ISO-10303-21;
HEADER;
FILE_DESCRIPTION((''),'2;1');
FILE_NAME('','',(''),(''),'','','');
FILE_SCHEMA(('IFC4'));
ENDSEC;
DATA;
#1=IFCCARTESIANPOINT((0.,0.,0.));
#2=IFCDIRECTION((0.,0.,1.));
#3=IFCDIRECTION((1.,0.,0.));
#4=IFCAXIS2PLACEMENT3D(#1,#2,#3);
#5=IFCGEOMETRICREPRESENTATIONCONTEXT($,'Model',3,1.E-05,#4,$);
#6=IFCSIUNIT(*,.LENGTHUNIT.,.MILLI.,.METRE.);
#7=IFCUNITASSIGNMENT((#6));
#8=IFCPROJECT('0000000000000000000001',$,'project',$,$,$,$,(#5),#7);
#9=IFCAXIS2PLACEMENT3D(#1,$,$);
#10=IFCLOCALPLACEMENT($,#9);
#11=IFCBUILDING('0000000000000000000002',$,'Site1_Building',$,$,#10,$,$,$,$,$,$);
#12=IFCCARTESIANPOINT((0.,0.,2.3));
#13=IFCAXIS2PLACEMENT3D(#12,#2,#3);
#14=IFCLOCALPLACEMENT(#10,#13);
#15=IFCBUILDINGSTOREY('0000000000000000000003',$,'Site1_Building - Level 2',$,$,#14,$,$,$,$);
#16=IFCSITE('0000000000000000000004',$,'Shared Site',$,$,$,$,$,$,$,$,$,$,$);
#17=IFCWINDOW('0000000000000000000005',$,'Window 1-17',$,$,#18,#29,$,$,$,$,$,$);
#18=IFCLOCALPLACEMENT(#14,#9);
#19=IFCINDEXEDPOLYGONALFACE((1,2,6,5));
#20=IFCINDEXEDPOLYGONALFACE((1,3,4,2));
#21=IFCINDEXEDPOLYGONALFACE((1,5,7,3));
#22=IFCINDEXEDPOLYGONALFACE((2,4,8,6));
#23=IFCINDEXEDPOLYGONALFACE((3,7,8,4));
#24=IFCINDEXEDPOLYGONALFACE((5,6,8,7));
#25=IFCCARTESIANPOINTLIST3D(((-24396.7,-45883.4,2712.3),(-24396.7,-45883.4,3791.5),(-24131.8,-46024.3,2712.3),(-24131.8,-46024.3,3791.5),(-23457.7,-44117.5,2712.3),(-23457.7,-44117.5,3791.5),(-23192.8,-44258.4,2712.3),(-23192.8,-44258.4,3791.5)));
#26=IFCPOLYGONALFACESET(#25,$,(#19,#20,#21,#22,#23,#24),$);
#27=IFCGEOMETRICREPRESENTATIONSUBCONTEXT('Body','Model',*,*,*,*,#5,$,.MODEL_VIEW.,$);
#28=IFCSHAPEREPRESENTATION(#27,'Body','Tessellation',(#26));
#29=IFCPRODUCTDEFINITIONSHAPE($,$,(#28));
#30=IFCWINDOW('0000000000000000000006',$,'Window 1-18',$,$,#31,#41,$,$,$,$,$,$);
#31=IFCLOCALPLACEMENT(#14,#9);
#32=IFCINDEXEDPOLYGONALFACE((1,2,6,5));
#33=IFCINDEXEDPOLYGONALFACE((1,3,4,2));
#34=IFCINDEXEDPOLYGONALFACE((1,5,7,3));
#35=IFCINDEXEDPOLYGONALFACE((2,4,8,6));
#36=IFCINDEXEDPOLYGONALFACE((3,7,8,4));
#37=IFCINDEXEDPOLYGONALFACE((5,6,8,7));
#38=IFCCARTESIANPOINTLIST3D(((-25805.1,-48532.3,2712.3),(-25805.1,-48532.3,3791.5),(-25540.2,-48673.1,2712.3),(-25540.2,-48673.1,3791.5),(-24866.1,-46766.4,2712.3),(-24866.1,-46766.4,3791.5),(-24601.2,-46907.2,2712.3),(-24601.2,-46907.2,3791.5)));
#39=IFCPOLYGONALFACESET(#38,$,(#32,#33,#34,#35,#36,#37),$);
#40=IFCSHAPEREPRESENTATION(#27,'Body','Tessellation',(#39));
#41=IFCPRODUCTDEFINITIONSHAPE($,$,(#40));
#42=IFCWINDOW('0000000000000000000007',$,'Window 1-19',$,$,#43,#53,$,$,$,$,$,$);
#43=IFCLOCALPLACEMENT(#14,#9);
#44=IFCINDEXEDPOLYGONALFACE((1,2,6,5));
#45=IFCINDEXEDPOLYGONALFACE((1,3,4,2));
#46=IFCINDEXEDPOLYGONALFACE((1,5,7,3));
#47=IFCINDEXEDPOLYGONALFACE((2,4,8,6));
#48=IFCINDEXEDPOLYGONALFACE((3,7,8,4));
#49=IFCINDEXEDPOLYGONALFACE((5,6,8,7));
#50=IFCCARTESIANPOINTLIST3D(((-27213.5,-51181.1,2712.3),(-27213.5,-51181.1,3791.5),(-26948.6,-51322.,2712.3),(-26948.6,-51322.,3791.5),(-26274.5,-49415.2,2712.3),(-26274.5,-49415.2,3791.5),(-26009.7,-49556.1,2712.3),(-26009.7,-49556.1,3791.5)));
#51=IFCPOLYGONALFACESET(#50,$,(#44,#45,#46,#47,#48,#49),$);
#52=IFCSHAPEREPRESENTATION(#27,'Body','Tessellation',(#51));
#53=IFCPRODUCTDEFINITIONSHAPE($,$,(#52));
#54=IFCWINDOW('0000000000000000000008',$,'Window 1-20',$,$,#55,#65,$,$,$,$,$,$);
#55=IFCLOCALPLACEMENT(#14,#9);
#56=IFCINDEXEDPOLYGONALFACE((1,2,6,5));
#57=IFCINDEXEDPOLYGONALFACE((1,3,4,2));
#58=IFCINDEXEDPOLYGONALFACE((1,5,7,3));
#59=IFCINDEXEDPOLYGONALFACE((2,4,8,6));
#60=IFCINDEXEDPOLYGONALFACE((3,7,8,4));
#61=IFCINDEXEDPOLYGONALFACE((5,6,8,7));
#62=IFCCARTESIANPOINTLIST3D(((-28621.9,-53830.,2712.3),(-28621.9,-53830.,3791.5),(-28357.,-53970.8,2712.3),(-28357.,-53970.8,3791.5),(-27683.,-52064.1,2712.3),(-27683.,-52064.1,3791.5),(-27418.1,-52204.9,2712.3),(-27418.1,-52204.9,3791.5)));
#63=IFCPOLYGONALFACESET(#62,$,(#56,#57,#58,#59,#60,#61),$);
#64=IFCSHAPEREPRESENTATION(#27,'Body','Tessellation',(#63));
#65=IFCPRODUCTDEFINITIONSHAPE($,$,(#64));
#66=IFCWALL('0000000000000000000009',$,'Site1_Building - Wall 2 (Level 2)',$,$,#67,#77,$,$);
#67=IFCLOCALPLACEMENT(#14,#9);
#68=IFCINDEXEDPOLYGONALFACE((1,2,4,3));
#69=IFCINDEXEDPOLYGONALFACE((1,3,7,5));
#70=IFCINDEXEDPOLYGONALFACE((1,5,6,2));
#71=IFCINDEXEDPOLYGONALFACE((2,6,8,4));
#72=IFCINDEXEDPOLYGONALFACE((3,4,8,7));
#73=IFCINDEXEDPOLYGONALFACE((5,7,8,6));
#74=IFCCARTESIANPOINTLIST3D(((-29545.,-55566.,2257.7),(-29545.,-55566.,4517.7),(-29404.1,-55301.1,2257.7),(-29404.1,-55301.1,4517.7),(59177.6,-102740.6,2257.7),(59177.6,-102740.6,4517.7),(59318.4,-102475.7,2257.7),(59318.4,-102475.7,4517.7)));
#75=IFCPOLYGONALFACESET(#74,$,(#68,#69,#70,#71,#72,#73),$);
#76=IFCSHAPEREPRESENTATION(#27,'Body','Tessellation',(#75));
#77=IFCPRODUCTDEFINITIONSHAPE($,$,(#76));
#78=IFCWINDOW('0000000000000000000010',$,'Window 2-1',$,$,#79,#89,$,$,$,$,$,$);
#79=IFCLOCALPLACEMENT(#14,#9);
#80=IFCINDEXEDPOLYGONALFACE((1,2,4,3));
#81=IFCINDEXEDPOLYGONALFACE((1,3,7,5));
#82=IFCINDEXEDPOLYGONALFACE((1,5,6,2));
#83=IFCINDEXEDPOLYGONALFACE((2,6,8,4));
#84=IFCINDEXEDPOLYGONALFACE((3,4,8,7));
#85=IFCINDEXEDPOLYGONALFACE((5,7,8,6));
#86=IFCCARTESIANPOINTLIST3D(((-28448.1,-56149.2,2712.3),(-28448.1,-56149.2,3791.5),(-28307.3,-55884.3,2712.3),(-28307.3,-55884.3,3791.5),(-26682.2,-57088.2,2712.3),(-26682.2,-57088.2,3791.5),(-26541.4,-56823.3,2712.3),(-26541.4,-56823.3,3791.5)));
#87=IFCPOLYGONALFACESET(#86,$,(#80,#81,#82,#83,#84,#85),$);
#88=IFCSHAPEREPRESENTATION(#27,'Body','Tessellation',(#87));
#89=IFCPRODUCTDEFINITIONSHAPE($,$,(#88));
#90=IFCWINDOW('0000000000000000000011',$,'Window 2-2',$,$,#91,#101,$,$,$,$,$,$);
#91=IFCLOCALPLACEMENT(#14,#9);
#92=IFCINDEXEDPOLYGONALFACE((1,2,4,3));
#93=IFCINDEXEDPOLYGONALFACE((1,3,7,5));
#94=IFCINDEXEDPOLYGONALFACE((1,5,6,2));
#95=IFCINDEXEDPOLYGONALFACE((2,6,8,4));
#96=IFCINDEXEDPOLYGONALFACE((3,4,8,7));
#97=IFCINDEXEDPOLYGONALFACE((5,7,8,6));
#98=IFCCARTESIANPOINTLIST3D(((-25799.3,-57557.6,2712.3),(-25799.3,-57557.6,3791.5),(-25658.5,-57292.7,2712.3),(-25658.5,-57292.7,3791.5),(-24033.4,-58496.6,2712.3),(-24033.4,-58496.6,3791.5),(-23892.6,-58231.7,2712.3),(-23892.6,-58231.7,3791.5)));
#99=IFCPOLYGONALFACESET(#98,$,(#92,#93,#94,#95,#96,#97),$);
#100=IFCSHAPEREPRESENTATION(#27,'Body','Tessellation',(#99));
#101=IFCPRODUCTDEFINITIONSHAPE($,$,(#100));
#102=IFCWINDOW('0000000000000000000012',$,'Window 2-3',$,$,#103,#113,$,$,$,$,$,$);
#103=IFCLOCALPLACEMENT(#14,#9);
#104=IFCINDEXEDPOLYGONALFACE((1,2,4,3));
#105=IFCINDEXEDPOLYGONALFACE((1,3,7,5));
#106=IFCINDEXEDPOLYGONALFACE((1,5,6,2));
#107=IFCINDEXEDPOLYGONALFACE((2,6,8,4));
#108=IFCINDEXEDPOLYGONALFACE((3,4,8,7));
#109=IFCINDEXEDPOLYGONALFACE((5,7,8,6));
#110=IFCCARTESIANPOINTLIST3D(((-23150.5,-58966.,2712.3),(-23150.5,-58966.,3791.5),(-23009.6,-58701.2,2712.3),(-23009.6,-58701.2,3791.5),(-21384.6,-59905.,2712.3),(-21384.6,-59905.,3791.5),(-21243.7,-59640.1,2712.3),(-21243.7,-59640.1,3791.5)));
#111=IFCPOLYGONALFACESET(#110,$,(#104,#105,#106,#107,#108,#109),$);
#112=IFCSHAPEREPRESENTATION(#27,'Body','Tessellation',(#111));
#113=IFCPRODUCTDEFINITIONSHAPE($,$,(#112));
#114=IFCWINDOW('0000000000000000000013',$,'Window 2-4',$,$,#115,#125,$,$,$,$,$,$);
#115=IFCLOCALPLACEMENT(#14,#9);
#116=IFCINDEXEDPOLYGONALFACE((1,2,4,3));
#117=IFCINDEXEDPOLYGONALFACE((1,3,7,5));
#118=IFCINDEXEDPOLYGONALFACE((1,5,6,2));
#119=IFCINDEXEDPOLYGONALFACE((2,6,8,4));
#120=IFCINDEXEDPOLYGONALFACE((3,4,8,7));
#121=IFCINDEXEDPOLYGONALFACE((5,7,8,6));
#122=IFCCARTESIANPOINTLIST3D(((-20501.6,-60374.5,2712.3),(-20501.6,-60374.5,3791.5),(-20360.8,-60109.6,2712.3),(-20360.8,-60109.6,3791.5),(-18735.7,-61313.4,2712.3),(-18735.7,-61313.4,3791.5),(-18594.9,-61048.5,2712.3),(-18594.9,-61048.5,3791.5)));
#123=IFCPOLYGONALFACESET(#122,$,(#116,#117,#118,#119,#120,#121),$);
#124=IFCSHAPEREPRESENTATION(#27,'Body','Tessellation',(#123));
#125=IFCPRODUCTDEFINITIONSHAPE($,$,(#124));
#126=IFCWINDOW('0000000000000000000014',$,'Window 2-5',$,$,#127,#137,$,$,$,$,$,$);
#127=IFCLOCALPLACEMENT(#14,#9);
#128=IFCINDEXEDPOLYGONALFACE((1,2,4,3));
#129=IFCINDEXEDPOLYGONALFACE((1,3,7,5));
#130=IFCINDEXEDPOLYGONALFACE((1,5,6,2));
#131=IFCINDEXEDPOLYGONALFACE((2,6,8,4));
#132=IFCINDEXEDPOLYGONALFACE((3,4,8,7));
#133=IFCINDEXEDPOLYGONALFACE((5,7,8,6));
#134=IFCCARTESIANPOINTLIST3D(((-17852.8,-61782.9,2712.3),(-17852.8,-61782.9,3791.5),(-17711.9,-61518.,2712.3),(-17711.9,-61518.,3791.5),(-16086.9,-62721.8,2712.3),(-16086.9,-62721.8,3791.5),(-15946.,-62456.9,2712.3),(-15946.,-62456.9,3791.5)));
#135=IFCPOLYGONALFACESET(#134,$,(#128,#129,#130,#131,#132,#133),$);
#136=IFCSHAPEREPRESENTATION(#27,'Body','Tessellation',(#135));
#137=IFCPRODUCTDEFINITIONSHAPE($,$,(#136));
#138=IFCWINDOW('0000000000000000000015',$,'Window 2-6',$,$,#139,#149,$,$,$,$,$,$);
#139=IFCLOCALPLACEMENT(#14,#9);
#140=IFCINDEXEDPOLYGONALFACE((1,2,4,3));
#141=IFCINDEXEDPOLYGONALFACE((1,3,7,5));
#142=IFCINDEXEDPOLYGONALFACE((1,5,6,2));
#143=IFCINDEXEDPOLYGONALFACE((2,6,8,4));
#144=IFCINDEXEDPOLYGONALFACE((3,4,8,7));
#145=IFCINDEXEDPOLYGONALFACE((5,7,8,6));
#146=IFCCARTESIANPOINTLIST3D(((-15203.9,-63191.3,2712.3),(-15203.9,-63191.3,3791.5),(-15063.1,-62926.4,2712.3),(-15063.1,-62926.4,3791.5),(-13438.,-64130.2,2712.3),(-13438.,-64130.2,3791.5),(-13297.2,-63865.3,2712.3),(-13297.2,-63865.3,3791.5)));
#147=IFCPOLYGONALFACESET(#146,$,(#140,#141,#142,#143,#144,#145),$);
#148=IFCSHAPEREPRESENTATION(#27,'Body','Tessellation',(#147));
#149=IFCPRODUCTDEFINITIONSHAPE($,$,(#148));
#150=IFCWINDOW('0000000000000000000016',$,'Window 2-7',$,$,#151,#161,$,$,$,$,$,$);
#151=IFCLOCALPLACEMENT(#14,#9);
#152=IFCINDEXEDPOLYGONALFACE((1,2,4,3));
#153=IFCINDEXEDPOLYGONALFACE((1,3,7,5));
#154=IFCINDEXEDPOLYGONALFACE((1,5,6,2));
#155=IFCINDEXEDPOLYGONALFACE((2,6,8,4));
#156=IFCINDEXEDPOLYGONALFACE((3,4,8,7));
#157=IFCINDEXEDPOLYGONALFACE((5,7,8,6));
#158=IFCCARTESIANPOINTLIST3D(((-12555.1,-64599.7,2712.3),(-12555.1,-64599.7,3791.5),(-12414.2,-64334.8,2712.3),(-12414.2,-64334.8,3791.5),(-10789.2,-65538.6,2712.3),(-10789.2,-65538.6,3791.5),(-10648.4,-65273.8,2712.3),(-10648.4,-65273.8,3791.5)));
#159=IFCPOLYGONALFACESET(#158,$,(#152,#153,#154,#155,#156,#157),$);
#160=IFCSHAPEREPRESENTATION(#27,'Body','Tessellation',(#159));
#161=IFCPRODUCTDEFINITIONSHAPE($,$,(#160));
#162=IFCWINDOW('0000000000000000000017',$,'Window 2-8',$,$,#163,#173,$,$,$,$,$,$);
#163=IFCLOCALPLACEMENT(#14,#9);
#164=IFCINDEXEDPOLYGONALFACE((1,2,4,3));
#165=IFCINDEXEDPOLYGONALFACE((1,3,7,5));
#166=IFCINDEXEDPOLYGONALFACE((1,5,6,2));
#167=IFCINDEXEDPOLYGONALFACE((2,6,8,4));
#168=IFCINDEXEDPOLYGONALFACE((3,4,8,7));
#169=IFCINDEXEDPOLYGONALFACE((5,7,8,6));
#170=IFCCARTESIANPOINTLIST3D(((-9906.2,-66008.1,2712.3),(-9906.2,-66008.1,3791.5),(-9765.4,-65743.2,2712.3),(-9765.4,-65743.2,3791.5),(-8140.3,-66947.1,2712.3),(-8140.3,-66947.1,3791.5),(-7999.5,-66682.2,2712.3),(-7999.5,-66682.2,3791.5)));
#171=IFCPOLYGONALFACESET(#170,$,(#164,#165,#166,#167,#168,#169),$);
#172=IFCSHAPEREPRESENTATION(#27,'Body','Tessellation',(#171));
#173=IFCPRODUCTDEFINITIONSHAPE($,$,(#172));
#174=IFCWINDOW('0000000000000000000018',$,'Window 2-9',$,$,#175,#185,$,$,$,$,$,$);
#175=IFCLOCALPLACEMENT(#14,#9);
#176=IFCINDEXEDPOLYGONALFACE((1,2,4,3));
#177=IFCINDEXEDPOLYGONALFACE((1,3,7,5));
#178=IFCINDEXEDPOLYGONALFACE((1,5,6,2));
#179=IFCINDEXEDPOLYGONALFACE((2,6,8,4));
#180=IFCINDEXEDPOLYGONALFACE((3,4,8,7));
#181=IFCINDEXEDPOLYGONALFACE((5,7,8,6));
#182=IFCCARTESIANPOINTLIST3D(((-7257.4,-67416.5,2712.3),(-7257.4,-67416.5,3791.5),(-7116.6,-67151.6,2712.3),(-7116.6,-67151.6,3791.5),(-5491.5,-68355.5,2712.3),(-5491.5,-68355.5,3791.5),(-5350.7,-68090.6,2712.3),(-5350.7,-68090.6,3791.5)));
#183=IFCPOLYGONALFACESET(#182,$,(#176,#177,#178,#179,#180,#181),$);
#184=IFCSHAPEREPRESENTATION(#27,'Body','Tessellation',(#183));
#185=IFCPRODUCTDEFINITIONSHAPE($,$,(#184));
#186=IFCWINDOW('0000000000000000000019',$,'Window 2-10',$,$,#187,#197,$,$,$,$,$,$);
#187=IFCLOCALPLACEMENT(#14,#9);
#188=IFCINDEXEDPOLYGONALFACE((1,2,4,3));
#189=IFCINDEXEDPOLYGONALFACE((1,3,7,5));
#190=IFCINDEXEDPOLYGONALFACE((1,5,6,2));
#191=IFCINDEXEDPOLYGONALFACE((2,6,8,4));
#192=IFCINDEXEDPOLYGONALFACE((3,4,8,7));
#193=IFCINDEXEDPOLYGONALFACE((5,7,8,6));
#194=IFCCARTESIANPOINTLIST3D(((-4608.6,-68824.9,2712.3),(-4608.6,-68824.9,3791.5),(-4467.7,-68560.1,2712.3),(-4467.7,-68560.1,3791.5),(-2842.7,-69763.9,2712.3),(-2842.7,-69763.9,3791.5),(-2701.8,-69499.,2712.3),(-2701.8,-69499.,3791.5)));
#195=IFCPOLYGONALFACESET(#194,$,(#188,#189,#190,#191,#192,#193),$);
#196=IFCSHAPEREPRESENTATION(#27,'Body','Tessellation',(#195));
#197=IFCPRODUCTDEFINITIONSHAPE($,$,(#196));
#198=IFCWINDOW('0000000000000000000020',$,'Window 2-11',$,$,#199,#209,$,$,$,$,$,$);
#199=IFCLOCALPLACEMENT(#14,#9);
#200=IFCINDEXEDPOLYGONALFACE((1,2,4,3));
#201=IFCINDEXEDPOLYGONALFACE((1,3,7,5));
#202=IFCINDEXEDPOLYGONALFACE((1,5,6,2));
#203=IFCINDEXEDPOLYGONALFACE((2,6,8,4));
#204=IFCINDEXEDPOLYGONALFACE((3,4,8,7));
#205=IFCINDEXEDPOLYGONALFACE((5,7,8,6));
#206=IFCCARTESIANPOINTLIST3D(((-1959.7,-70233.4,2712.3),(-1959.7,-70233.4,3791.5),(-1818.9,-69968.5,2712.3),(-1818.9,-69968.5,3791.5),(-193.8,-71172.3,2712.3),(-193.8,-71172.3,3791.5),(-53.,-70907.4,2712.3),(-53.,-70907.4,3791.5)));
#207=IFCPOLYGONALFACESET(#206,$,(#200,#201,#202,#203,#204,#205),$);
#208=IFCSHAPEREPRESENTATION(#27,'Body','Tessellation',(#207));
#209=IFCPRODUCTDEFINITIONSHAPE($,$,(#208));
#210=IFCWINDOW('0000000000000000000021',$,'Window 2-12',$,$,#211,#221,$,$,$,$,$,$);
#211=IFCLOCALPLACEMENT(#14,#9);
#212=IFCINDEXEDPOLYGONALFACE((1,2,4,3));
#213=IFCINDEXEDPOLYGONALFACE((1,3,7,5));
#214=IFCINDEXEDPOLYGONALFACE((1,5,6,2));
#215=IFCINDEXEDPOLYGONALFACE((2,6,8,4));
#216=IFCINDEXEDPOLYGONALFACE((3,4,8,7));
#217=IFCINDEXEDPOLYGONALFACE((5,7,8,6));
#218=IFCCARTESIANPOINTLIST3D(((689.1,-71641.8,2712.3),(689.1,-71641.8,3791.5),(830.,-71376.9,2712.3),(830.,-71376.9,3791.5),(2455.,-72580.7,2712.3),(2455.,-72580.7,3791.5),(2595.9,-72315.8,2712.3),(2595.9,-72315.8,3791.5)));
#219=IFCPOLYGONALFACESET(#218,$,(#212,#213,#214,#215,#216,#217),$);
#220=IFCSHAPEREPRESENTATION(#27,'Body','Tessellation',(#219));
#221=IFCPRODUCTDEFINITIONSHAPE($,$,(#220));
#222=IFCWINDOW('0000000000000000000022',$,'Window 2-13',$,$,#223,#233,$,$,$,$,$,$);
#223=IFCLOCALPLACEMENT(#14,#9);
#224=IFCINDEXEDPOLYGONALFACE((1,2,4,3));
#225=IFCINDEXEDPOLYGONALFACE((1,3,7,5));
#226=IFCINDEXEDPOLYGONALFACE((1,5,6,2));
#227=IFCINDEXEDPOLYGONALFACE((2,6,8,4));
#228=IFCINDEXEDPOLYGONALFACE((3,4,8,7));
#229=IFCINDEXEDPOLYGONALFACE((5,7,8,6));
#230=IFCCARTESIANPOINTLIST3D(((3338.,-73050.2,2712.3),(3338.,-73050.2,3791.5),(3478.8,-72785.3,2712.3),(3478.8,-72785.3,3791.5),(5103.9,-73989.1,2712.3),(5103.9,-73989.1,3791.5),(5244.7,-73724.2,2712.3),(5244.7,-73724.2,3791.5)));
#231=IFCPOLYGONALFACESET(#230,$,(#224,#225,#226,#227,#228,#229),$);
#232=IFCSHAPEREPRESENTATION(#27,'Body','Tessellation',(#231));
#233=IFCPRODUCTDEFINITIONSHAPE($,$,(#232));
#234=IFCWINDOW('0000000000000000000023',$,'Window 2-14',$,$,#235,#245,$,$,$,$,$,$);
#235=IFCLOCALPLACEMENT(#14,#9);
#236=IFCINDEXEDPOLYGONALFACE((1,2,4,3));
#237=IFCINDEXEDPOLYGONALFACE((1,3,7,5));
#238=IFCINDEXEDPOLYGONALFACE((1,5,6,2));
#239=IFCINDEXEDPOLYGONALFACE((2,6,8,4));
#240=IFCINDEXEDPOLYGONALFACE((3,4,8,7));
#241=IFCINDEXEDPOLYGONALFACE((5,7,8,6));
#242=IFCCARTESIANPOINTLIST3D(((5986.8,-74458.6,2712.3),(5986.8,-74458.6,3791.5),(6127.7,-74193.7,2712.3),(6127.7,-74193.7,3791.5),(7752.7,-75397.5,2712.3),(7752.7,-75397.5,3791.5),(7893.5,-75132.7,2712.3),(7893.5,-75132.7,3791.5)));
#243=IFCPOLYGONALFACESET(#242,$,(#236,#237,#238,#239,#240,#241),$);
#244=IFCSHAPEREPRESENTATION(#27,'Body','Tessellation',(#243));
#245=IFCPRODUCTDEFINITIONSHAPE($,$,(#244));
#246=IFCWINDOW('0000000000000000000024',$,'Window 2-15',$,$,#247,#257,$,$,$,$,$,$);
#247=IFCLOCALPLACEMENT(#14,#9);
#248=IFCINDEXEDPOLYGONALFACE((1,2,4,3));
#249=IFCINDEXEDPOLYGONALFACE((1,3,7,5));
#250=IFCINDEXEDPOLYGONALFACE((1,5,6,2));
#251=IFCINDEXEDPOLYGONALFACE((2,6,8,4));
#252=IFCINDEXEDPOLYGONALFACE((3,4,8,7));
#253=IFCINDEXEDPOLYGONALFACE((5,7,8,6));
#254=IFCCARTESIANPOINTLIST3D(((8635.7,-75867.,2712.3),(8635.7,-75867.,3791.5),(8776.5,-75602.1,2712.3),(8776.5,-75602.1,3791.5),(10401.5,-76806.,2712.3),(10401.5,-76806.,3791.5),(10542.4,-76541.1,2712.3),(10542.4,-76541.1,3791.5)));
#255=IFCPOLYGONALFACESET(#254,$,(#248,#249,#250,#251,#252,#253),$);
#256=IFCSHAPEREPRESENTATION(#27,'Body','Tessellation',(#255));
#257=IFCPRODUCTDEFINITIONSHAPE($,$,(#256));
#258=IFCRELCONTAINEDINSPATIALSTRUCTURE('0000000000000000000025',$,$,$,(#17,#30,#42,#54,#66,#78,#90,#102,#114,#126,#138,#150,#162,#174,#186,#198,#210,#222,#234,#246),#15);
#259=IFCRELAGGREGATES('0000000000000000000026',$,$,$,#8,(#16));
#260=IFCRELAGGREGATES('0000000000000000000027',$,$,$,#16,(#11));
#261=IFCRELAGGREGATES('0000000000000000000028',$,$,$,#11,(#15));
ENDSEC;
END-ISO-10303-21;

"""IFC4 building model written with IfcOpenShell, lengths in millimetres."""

from ifc_helpers import new_model, si_unit, frame, origin, origin_with_axes, place, context, subcontext, project, spatial, indexed_curve, outline, extrude, element, save


model = new_model("IFC4")

# Units and contexts
model_context = context("Model", 3, precision=1e-05, world=origin_with_axes())
body_context = subcontext(model_context, "Body", "Model", "MODEL_VIEW")
ifc_project = project(units=[si_unit("LENGTHUNIT", "METRE", prefix="MILLI")], contexts=[model_context])

# Site, building, storey
site = spatial("IfcSite", under=ifc_project, Name="Shared Site")
building_placement = place(None, origin())
building = spatial("IfcBuilding", under=site, at=building_placement, Name="Site1_Building")
storey_placement = place(building_placement, frame((0.0, 0.0, 2.3), z_axis=(0.0, 0.0, 1.0), x_axis=(1.0, 0.0, 0.0)))
storey = spatial("IfcBuildingStorey", under=building, at=storey_placement, Name="Site1_Building - Level 2")

# Windows
for number, where, z_axis, x_axis, name in (
    (1, (-23457.7, -44117.5, 2712.3), (0.0, 0.0, 1.0), (-0.469472, -0.882948, 0.0), "Window 1-17"),
    (2, (-24866.1, -46766.4, 2712.3), (0.0, 0.0, 1.0), (-0.469472, -0.882948, 0.0), "Window 1-18"),
    (3, (-26274.5, -49415.2, 2712.3), (0.0, 0.0, 1.0), (-0.469472, -0.882948, 0.0), "Window 1-19"),
    (4, (-27683.0, -52064.1, 2712.3), (0.0, 0.0, 1.0), (-0.469472, -0.882948, 0.0), "Window 1-20"),
):
    element("IfcWindow", number, at=place(storey_placement, frame(where, z_axis=z_axis, x_axis=x_axis)), inside=storey, Name=name, context=body_context, shape_type="SweptSolid", body=[
        extrude(outline(indexed_curve([(0.0, 0.0), (0.0, 300.0), (2000.0, 300.0), (2000.0, 0.0), (0.0, 0.0)], self_intersect=False)), origin_with_axes(), (0.0, 0.0, 1.0), 1079.3),
    ])

# Wall
wall_placement = place(storey_placement, frame((-29545.0, -55566.0, 2257.7), z_axis=(0.0, 0.0, 1.0), x_axis=(0.882948, -0.469472, 0.0)))
element("IfcWall", 5, at=wall_placement, inside=storey, Name="Site1_Building - Wall 2 (Level 2)", context=body_context, shape_type="SweptSolid", body=[
    extrude(outline(indexed_curve([(0.0, 0.0), (0.0, 300.0), (100484.5, 300.0), (100484.5, 0.0), (0.0, 0.0)], self_intersect=False)), origin_with_axes(), (0.0, 0.0, 1.0), 2260.0),
])

# Windows
for number, where, z_axis, x_axis, name in (
    (6, (-28448.1, -56149.2, 2712.3), (0.0, 0.0, 1.0), (0.882948, -0.469472, 0.0), "Window 2-1"),
    (7, (-25799.3, -57557.6, 2712.3), (0.0, 0.0, 1.0), (0.882948, -0.469472, 0.0), "Window 2-2"),
    (8, (-23150.5, -58966.0, 2712.3), (0.0, 0.0, 1.0), (0.882948, -0.469472, 0.0), "Window 2-3"),
    (9, (-20501.6, -60374.5, 2712.3), (0.0, 0.0, 1.0), (0.882948, -0.469472, 0.0), "Window 2-4"),
    (10, (-17852.8, -61782.9, 2712.3), (0.0, 0.0, 1.0), (0.882948, -0.469472, 0.0), "Window 2-5"),
    (11, (-15203.9, -63191.3, 2712.3), (0.0, 0.0, 1.0), (0.882948, -0.469472, 0.0), "Window 2-6"),
    (12, (-12555.1, -64599.7, 2712.3), (0.0, 0.0, 1.0), (0.882948, -0.469472, 0.0), "Window 2-7"),
    (13, (-9906.2, -66008.1, 2712.3), (0.0, 0.0, 1.0), (0.882948, -0.469472, 0.0), "Window 2-8"),
    (14, (-7257.4, -67416.5, 2712.3), (0.0, 0.0, 1.0), (0.882948, -0.469472, 0.0), "Window 2-9"),
    (15, (-4608.6, -68824.9, 2712.3), (0.0, 0.0, 1.0), (0.882948, -0.469472, 0.0), "Window 2-10"),
    (16, (-1959.7, -70233.4, 2712.3), (0.0, 0.0, 1.0), (0.882948, -0.469472, 0.0), "Window 2-11"),
    (17, (689.1, -71641.8, 2712.3), (0.0, 0.0, 1.0), (0.882948, -0.469472, 0.0), "Window 2-12"),
    (18, (3338.0, -73050.2, 2712.3), (0.0, 0.0, 1.0), (0.882948, -0.469472, 0.0), "Window 2-13"),
    (19, (5986.8, -74458.6, 2712.3), (0.0, 0.0, 1.0), (0.882948, -0.469472, 0.0), "Window 2-14"),
    (20, (8635.7, -75867.0, 2712.3), (0.0, 0.0, 1.0), (0.882948, -0.469472, 0.0), "Window 2-15"),
):
    element("IfcWindow", number, at=place(storey_placement, frame(where, z_axis=z_axis, x_axis=x_axis)), inside=storey, Name=name, context=body_context, shape_type="SweptSolid", body=[
        extrude(outline(indexed_curve([(0.0, 0.0), (0.0, 300.0), (2000.0, 300.0), (2000.0, 0.0), (0.0, 0.0)], self_intersect=False)), origin_with_axes(), (0.0, 0.0, 1.0), 1079.3),
    ])

save(model, "model.ifc")
